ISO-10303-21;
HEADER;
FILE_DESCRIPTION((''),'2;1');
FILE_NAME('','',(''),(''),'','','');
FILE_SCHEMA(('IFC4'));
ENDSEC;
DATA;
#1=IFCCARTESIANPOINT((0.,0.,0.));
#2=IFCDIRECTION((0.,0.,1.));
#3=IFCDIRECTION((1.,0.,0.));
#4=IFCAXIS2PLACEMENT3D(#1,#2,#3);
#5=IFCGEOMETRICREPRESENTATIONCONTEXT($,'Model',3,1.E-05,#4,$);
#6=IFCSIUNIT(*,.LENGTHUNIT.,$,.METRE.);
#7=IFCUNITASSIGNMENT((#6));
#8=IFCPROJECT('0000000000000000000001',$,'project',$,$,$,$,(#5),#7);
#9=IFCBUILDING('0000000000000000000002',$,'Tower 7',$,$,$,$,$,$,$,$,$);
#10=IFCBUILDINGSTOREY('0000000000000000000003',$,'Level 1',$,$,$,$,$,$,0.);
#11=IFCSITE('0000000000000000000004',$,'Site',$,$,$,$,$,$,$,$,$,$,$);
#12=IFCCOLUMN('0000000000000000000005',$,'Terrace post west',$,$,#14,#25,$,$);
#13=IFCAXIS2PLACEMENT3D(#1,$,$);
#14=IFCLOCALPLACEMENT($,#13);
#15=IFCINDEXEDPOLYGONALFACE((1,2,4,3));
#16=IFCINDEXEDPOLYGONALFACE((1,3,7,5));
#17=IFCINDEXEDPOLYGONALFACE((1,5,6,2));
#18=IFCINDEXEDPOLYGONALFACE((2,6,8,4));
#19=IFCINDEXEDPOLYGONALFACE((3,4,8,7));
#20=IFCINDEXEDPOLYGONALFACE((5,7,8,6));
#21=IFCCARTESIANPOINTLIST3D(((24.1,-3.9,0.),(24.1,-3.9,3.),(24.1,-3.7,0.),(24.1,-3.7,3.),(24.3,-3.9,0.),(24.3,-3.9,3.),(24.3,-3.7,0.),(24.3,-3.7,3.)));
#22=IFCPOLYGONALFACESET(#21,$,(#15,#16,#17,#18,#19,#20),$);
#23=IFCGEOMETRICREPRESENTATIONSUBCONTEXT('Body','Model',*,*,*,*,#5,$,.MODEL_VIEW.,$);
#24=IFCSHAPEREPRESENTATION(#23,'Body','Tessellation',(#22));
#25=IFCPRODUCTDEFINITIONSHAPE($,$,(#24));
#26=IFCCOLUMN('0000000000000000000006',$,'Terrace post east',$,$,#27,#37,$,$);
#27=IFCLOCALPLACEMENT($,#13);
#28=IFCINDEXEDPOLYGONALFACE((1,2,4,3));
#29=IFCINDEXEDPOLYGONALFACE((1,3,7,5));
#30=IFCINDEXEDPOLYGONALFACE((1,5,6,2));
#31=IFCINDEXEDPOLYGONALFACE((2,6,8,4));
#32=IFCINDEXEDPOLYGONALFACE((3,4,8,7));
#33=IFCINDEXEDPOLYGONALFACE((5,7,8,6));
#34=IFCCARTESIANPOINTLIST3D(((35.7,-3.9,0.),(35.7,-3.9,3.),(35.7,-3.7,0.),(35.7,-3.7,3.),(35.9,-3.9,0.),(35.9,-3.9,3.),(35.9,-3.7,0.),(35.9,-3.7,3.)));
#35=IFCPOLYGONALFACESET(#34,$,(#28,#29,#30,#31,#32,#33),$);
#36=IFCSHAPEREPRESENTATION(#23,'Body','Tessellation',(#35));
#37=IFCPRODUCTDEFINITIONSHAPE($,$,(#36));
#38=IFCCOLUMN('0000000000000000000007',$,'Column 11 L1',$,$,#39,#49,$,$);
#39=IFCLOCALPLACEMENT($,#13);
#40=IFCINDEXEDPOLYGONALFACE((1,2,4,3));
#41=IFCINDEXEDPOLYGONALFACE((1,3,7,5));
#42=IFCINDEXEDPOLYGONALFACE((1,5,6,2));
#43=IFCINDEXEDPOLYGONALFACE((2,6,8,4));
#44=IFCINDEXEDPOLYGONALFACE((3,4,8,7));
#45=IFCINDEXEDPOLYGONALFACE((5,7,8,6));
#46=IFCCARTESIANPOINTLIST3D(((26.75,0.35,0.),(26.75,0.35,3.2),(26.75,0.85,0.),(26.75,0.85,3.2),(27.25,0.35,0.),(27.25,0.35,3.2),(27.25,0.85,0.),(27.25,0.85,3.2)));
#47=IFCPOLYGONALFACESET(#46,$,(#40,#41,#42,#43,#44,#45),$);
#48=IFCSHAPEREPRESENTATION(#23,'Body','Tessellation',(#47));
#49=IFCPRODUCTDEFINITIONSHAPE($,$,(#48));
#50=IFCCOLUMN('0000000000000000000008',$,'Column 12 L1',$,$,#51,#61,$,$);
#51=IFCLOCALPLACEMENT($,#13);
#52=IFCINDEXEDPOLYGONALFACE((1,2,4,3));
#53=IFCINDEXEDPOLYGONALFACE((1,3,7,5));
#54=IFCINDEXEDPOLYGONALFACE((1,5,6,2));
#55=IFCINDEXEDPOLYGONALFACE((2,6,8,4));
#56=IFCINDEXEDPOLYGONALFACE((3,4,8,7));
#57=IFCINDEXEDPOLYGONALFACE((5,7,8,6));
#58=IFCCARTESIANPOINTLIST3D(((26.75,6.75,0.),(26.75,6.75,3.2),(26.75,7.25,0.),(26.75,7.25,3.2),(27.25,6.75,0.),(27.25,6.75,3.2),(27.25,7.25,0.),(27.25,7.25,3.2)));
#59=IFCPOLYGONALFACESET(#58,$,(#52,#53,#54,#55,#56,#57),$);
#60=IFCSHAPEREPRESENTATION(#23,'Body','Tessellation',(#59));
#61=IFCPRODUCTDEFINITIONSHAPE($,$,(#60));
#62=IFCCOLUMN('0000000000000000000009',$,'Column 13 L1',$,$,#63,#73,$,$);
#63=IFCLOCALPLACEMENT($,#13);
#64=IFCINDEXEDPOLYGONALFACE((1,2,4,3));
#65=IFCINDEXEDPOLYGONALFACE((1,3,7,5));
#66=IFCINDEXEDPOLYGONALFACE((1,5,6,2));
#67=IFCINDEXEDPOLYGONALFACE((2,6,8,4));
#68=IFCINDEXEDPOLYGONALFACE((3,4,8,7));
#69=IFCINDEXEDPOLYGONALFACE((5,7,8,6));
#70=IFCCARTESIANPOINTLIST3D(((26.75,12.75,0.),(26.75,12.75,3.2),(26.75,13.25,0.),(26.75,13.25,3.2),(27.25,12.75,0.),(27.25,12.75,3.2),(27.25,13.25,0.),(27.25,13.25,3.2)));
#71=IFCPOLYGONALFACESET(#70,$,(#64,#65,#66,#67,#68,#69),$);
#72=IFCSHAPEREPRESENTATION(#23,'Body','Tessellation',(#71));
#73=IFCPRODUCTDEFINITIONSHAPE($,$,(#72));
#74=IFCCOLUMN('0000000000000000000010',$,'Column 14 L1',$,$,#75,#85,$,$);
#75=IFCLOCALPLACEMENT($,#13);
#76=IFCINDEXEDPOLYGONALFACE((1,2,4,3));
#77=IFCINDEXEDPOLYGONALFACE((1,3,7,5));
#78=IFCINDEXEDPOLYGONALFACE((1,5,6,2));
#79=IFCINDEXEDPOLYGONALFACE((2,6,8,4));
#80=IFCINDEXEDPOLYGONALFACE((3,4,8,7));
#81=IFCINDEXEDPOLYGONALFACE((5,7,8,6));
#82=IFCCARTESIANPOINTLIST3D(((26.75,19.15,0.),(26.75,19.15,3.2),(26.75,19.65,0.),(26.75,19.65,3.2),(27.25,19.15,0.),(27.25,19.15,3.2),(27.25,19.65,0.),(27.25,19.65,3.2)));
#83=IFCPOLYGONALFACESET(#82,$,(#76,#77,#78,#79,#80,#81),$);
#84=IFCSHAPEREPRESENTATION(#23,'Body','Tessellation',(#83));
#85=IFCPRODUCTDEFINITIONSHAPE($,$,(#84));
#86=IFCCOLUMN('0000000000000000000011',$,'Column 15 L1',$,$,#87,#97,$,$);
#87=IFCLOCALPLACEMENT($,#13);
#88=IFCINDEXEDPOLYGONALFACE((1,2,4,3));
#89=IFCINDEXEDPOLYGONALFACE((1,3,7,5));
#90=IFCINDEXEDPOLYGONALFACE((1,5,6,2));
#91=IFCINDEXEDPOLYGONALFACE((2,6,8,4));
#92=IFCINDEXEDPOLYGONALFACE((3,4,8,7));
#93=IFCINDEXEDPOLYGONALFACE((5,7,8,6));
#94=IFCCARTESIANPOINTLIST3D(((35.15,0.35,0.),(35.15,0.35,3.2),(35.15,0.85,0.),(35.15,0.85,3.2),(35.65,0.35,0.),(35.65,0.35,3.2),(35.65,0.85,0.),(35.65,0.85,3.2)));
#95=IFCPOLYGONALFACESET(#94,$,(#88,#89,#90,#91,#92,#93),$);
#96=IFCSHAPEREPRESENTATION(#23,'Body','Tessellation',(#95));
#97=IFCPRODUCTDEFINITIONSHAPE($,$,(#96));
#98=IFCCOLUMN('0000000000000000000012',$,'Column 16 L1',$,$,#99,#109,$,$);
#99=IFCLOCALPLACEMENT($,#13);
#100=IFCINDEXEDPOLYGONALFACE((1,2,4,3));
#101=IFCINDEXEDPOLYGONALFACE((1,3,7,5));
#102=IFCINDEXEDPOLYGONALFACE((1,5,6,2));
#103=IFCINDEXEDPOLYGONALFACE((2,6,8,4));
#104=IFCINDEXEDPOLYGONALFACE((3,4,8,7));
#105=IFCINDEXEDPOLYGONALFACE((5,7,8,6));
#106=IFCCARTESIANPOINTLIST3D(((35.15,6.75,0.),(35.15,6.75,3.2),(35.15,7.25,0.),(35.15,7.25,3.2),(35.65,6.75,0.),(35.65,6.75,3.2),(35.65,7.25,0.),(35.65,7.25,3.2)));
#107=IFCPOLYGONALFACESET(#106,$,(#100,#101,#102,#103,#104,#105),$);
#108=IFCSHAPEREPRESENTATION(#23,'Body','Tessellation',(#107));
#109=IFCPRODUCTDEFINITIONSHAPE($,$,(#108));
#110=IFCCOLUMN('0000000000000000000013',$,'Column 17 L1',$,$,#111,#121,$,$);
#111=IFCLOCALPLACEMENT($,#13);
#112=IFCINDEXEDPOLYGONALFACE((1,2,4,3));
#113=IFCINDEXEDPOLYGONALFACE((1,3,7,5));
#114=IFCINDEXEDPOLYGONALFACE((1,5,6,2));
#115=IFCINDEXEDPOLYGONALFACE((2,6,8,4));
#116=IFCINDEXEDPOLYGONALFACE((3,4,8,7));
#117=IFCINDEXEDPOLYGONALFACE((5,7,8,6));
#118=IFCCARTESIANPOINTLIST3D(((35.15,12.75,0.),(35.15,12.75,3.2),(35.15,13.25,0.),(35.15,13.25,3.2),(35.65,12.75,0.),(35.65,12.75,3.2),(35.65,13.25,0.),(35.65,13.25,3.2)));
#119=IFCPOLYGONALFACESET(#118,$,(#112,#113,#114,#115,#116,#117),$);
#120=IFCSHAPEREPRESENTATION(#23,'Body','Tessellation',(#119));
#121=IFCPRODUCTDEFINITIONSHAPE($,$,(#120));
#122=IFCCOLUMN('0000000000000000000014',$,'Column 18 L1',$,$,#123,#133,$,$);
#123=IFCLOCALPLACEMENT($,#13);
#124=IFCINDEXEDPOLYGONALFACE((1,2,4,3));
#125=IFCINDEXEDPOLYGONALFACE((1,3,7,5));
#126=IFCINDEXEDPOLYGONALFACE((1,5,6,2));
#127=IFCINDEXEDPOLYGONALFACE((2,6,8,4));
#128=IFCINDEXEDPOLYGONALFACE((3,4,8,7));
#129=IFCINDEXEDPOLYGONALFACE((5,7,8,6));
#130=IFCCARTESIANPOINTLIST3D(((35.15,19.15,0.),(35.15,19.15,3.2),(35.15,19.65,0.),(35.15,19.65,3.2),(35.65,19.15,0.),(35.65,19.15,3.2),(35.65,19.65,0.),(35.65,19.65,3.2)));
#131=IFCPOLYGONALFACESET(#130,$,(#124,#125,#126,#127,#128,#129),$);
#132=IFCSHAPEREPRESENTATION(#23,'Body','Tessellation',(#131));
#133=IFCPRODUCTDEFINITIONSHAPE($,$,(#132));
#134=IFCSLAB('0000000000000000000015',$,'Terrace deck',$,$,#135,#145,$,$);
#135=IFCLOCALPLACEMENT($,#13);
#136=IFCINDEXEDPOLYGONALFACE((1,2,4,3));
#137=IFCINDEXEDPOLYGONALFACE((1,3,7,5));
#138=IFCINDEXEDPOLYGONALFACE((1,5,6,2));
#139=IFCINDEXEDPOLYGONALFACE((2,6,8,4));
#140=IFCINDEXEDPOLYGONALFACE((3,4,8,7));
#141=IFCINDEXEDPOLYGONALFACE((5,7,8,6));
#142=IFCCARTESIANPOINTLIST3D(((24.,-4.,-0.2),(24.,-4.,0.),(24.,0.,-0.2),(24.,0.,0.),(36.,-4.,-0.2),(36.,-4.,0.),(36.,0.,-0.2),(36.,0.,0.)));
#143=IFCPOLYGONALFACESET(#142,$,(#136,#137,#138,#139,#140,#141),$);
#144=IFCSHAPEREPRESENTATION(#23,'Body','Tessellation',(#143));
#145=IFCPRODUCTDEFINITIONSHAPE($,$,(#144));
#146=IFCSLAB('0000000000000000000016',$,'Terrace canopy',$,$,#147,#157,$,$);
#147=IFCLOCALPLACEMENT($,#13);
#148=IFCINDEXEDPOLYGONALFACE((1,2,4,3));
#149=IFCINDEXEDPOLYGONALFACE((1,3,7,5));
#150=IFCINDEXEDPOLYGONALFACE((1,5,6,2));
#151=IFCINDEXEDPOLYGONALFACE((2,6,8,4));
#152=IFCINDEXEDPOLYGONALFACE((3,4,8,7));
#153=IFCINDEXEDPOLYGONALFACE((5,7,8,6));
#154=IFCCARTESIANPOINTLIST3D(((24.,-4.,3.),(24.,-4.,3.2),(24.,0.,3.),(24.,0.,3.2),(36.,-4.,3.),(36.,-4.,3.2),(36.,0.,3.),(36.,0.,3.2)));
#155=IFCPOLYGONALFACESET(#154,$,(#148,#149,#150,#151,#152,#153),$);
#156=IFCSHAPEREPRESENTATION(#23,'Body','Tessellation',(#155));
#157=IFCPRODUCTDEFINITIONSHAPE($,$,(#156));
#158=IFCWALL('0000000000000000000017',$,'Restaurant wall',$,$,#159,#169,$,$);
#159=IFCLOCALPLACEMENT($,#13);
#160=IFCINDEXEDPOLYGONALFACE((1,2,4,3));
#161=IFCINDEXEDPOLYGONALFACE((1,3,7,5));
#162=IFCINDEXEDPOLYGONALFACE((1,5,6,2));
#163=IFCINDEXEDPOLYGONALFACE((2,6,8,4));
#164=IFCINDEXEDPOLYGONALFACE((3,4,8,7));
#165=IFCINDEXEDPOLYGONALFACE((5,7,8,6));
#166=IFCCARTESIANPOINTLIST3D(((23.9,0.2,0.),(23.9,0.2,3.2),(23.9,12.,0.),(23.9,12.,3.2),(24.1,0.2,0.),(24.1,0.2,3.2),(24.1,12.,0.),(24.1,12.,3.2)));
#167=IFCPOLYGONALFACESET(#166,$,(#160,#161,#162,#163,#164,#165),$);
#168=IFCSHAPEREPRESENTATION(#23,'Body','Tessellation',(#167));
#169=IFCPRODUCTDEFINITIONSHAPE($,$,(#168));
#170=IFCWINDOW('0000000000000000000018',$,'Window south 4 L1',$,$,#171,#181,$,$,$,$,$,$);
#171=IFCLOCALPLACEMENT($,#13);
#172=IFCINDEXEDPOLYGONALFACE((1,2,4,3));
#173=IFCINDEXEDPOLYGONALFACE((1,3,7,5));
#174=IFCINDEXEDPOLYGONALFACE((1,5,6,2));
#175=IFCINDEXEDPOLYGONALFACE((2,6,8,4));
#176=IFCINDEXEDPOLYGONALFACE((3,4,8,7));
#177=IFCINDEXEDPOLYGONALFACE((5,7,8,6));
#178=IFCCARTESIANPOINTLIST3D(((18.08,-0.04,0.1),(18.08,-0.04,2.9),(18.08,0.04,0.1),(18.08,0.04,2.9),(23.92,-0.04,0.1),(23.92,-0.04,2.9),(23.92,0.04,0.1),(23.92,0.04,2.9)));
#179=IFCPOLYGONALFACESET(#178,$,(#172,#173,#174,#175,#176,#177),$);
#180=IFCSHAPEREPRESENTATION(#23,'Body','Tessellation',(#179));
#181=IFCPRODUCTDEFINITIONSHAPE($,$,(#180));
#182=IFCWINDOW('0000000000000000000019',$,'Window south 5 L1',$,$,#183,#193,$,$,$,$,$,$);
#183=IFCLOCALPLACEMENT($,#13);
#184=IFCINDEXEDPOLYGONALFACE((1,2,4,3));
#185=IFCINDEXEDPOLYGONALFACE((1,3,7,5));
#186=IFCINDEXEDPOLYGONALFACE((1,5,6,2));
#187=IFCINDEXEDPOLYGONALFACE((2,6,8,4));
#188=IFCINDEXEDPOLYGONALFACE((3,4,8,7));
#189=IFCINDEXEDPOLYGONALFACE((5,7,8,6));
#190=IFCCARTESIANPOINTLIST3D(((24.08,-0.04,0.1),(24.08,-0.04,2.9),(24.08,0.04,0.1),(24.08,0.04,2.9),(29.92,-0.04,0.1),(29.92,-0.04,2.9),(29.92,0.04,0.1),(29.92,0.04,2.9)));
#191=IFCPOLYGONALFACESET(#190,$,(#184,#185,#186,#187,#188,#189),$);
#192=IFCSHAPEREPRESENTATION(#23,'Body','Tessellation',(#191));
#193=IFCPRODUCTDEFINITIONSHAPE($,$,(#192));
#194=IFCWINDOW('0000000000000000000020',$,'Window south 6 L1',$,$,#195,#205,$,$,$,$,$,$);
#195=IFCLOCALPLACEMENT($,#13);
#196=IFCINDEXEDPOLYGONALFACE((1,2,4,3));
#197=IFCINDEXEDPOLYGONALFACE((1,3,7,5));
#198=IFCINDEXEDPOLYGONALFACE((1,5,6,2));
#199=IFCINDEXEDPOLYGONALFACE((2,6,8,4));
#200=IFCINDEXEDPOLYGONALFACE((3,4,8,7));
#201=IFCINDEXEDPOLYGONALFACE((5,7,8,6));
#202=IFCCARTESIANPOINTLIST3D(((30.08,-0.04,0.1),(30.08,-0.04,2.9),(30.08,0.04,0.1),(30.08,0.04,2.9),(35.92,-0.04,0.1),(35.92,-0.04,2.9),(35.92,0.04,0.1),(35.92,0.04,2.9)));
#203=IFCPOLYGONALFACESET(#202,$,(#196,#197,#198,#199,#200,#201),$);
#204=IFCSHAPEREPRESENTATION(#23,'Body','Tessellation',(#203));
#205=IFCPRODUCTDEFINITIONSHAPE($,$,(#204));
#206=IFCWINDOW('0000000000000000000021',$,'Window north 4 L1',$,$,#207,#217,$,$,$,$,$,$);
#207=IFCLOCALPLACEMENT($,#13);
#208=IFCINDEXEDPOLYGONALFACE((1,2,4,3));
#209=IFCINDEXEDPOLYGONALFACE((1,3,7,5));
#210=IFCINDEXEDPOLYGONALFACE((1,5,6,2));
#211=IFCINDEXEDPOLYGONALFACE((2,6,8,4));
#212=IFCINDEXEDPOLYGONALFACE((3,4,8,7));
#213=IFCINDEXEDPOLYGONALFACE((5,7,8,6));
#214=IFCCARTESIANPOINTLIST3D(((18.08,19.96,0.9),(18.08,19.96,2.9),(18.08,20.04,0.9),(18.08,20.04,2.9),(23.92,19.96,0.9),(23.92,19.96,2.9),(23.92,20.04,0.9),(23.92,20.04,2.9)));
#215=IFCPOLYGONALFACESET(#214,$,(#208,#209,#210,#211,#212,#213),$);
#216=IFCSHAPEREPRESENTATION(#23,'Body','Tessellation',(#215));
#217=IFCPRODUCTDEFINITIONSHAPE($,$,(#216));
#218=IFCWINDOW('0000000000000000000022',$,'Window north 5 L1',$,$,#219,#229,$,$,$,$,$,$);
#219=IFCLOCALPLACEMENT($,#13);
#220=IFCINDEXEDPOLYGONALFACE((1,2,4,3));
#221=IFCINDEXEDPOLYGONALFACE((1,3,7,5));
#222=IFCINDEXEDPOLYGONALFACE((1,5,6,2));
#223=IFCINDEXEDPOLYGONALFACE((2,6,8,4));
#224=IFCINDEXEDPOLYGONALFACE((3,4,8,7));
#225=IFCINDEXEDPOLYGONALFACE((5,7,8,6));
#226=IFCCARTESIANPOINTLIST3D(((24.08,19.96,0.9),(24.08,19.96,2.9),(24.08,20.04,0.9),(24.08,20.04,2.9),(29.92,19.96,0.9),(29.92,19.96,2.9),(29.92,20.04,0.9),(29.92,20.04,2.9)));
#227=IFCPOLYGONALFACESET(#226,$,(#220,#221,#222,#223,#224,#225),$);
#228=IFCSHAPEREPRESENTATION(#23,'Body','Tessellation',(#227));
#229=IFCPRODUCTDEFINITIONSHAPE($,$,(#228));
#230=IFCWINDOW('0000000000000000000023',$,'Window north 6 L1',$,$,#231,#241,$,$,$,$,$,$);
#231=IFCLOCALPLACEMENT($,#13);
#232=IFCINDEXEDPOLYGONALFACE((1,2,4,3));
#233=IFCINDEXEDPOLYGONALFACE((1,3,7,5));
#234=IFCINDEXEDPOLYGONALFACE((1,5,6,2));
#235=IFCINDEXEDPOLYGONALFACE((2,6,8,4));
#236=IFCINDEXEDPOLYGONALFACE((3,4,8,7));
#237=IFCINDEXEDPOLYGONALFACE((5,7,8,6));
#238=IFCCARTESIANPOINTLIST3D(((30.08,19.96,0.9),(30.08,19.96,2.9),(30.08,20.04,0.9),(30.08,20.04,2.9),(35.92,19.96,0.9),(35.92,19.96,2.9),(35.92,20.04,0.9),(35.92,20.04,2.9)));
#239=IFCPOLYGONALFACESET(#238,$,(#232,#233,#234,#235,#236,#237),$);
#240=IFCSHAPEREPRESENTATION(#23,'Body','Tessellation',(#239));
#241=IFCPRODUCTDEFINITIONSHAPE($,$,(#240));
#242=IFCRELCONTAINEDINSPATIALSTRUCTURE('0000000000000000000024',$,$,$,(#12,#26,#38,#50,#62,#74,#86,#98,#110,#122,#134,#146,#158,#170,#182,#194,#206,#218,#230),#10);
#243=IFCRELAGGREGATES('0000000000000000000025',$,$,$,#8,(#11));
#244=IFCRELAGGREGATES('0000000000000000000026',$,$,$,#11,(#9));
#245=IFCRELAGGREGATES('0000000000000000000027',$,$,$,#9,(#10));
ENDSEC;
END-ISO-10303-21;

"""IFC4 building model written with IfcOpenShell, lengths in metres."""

from ifc_helpers import new_model, si_unit, frame, origin, origin_with_axes, origin_2d, place, context, subcontext, project, spatial, rectangle, extrude, element, save


model = new_model("IFC4")

# Units and contexts
model_context = context("Model", 3, precision=1e-05, world=origin_with_axes())
body_context = subcontext(model_context, "Body", "Model", "MODEL_VIEW")
ifc_project = project(units=[si_unit("LENGTHUNIT", "METRE")], contexts=[model_context])

# Site, building, storey
site = spatial("IfcSite", under=ifc_project, Name="Site")
building = spatial("IfcBuilding", under=site, Name="Tower 7")
storey = spatial("IfcBuildingStorey", under=building, Name="Level 1", Elevation=0.0)

# Columns
column_1_placement = place(None, frame((24.2, -3.8, 0.0), z_axis=(0.0, 0.0, 1.0), x_axis=(1.0, 0.0, 0.0)))
element("IfcColumn", 1, at=column_1_placement, inside=storey, Name="Terrace post west", context=body_context, shape_type="SweptSolid", body=[
    extrude(rectangle(XDim=0.2, YDim=0.2, at=origin_2d()), origin(), (0.0, 0.0, 1.0), 3.0),
])
column_2_placement = place(None, frame((35.8, -3.8, 0.0), z_axis=(0.0, 0.0, 1.0), x_axis=(1.0, 0.0, 0.0)))
element("IfcColumn", 2, at=column_2_placement, inside=storey, Name="Terrace post east", context=body_context, shape_type="SweptSolid", body=[
    extrude(rectangle(XDim=0.2, YDim=0.2, at=origin_2d()), origin(), (0.0, 0.0, 1.0), 3.0),
])
for number, where, z_axis, x_axis, name in (
    (3, (27.0, 0.6, 0.0), (0.0, 0.0, 1.0), (1.0, 0.0, 0.0), "Column 11 L1"),
    (4, (27.0, 7.0, 0.0), (0.0, 0.0, 1.0), (1.0, 0.0, 0.0), "Column 12 L1"),
    (5, (27.0, 13.0, 0.0), (0.0, 0.0, 1.0), (1.0, 0.0, 0.0), "Column 13 L1"),
    (6, (27.0, 19.4, 0.0), (0.0, 0.0, 1.0), (1.0, 0.0, 0.0), "Column 14 L1"),
    (7, (35.4, 0.6, 0.0), (0.0, 0.0, 1.0), (1.0, 0.0, 0.0), "Column 15 L1"),
    (8, (35.4, 7.0, 0.0), (0.0, 0.0, 1.0), (1.0, 0.0, 0.0), "Column 16 L1"),
    (9, (35.4, 13.0, 0.0), (0.0, 0.0, 1.0), (1.0, 0.0, 0.0), "Column 17 L1"),
    (10, (35.4, 19.4, 0.0), (0.0, 0.0, 1.0), (1.0, 0.0, 0.0), "Column 18 L1"),
):
    element("IfcColumn", number, at=place(None, frame(where, z_axis=z_axis, x_axis=x_axis)), inside=storey, Name=name, context=body_context, shape_type="SweptSolid", body=[
        extrude(rectangle(XDim=0.5, YDim=0.5, at=origin_2d()), origin(), (0.0, 0.0, 1.0), 3.2),
    ])

# Slabs
for number, where, z_axis, x_axis, name in (
    (11, (30.0, -2.0, -0.2), (0.0, 0.0, 1.0), (1.0, 0.0, 0.0), "Terrace deck"),
    (12, (30.0, -2.0, 3.0), (0.0, 0.0, 1.0), (1.0, 0.0, 0.0), "Terrace canopy"),
):
    element("IfcSlab", number, at=place(None, frame(where, z_axis=z_axis, x_axis=x_axis)), inside=storey, Name=name, context=body_context, shape_type="SweptSolid", body=[
        extrude(rectangle(XDim=12.0, YDim=4.0, at=origin_2d()), origin(), (0.0, 0.0, 1.0), 0.2),
    ])

# Wall
wall_1_placement = place(None, frame((24.0, 6.1, 0.0), z_axis=(0.0, 0.0, 1.0), x_axis=(1.0, 0.0, 0.0)))
element("IfcWall", 13, at=wall_1_placement, inside=storey, Name="Restaurant wall", context=body_context, shape_type="SweptSolid", body=[
    extrude(rectangle(XDim=0.2, YDim=11.8, at=origin_2d()), origin(), (0.0, 0.0, 1.0), 3.2),
])

# Windows
for number, where, z_axis, x_axis, name in (
    (14, (21.0, 0.0, 0.1), (0.0, 0.0, 1.0), (1.0, 0.0, 0.0), "Window south 4 L1"),
    (15, (27.0, 0.0, 0.1), (0.0, 0.0, 1.0), (1.0, 0.0, 0.0), "Window south 5 L1"),
    (16, (33.0, 0.0, 0.1), (0.0, 0.0, 1.0), (1.0, 0.0, 0.0), "Window south 6 L1"),
):
    element("IfcWindow", number, at=place(None, frame(where, z_axis=z_axis, x_axis=x_axis)), inside=storey, Name=name, context=body_context, shape_type="SweptSolid", body=[
        extrude(rectangle(XDim=5.84, YDim=0.08, at=origin_2d()), origin(), (0.0, 0.0, 1.0), 2.8),
    ])
for number, where, z_axis, x_axis, name in (
    (17, (21.0, 20.0, 0.9), (0.0, 0.0, 1.0), (1.0, 0.0, 0.0), "Window north 4 L1"),
    (18, (27.0, 20.0, 0.9), (0.0, 0.0, 1.0), (1.0, 0.0, 0.0), "Window north 5 L1"),
    (19, (33.0, 20.0, 0.9), (0.0, 0.0, 1.0), (1.0, 0.0, 0.0), "Window north 6 L1"),
):
    element("IfcWindow", number, at=place(None, frame(where, z_axis=z_axis, x_axis=x_axis)), inside=storey, Name=name, context=body_context, shape_type="SweptSolid", body=[
        extrude(rectangle(XDim=5.84, YDim=0.08, at=origin_2d()), origin(), (0.0, 0.0, 1.0), 2.0),
    ])

save(model, "model.ifc")
